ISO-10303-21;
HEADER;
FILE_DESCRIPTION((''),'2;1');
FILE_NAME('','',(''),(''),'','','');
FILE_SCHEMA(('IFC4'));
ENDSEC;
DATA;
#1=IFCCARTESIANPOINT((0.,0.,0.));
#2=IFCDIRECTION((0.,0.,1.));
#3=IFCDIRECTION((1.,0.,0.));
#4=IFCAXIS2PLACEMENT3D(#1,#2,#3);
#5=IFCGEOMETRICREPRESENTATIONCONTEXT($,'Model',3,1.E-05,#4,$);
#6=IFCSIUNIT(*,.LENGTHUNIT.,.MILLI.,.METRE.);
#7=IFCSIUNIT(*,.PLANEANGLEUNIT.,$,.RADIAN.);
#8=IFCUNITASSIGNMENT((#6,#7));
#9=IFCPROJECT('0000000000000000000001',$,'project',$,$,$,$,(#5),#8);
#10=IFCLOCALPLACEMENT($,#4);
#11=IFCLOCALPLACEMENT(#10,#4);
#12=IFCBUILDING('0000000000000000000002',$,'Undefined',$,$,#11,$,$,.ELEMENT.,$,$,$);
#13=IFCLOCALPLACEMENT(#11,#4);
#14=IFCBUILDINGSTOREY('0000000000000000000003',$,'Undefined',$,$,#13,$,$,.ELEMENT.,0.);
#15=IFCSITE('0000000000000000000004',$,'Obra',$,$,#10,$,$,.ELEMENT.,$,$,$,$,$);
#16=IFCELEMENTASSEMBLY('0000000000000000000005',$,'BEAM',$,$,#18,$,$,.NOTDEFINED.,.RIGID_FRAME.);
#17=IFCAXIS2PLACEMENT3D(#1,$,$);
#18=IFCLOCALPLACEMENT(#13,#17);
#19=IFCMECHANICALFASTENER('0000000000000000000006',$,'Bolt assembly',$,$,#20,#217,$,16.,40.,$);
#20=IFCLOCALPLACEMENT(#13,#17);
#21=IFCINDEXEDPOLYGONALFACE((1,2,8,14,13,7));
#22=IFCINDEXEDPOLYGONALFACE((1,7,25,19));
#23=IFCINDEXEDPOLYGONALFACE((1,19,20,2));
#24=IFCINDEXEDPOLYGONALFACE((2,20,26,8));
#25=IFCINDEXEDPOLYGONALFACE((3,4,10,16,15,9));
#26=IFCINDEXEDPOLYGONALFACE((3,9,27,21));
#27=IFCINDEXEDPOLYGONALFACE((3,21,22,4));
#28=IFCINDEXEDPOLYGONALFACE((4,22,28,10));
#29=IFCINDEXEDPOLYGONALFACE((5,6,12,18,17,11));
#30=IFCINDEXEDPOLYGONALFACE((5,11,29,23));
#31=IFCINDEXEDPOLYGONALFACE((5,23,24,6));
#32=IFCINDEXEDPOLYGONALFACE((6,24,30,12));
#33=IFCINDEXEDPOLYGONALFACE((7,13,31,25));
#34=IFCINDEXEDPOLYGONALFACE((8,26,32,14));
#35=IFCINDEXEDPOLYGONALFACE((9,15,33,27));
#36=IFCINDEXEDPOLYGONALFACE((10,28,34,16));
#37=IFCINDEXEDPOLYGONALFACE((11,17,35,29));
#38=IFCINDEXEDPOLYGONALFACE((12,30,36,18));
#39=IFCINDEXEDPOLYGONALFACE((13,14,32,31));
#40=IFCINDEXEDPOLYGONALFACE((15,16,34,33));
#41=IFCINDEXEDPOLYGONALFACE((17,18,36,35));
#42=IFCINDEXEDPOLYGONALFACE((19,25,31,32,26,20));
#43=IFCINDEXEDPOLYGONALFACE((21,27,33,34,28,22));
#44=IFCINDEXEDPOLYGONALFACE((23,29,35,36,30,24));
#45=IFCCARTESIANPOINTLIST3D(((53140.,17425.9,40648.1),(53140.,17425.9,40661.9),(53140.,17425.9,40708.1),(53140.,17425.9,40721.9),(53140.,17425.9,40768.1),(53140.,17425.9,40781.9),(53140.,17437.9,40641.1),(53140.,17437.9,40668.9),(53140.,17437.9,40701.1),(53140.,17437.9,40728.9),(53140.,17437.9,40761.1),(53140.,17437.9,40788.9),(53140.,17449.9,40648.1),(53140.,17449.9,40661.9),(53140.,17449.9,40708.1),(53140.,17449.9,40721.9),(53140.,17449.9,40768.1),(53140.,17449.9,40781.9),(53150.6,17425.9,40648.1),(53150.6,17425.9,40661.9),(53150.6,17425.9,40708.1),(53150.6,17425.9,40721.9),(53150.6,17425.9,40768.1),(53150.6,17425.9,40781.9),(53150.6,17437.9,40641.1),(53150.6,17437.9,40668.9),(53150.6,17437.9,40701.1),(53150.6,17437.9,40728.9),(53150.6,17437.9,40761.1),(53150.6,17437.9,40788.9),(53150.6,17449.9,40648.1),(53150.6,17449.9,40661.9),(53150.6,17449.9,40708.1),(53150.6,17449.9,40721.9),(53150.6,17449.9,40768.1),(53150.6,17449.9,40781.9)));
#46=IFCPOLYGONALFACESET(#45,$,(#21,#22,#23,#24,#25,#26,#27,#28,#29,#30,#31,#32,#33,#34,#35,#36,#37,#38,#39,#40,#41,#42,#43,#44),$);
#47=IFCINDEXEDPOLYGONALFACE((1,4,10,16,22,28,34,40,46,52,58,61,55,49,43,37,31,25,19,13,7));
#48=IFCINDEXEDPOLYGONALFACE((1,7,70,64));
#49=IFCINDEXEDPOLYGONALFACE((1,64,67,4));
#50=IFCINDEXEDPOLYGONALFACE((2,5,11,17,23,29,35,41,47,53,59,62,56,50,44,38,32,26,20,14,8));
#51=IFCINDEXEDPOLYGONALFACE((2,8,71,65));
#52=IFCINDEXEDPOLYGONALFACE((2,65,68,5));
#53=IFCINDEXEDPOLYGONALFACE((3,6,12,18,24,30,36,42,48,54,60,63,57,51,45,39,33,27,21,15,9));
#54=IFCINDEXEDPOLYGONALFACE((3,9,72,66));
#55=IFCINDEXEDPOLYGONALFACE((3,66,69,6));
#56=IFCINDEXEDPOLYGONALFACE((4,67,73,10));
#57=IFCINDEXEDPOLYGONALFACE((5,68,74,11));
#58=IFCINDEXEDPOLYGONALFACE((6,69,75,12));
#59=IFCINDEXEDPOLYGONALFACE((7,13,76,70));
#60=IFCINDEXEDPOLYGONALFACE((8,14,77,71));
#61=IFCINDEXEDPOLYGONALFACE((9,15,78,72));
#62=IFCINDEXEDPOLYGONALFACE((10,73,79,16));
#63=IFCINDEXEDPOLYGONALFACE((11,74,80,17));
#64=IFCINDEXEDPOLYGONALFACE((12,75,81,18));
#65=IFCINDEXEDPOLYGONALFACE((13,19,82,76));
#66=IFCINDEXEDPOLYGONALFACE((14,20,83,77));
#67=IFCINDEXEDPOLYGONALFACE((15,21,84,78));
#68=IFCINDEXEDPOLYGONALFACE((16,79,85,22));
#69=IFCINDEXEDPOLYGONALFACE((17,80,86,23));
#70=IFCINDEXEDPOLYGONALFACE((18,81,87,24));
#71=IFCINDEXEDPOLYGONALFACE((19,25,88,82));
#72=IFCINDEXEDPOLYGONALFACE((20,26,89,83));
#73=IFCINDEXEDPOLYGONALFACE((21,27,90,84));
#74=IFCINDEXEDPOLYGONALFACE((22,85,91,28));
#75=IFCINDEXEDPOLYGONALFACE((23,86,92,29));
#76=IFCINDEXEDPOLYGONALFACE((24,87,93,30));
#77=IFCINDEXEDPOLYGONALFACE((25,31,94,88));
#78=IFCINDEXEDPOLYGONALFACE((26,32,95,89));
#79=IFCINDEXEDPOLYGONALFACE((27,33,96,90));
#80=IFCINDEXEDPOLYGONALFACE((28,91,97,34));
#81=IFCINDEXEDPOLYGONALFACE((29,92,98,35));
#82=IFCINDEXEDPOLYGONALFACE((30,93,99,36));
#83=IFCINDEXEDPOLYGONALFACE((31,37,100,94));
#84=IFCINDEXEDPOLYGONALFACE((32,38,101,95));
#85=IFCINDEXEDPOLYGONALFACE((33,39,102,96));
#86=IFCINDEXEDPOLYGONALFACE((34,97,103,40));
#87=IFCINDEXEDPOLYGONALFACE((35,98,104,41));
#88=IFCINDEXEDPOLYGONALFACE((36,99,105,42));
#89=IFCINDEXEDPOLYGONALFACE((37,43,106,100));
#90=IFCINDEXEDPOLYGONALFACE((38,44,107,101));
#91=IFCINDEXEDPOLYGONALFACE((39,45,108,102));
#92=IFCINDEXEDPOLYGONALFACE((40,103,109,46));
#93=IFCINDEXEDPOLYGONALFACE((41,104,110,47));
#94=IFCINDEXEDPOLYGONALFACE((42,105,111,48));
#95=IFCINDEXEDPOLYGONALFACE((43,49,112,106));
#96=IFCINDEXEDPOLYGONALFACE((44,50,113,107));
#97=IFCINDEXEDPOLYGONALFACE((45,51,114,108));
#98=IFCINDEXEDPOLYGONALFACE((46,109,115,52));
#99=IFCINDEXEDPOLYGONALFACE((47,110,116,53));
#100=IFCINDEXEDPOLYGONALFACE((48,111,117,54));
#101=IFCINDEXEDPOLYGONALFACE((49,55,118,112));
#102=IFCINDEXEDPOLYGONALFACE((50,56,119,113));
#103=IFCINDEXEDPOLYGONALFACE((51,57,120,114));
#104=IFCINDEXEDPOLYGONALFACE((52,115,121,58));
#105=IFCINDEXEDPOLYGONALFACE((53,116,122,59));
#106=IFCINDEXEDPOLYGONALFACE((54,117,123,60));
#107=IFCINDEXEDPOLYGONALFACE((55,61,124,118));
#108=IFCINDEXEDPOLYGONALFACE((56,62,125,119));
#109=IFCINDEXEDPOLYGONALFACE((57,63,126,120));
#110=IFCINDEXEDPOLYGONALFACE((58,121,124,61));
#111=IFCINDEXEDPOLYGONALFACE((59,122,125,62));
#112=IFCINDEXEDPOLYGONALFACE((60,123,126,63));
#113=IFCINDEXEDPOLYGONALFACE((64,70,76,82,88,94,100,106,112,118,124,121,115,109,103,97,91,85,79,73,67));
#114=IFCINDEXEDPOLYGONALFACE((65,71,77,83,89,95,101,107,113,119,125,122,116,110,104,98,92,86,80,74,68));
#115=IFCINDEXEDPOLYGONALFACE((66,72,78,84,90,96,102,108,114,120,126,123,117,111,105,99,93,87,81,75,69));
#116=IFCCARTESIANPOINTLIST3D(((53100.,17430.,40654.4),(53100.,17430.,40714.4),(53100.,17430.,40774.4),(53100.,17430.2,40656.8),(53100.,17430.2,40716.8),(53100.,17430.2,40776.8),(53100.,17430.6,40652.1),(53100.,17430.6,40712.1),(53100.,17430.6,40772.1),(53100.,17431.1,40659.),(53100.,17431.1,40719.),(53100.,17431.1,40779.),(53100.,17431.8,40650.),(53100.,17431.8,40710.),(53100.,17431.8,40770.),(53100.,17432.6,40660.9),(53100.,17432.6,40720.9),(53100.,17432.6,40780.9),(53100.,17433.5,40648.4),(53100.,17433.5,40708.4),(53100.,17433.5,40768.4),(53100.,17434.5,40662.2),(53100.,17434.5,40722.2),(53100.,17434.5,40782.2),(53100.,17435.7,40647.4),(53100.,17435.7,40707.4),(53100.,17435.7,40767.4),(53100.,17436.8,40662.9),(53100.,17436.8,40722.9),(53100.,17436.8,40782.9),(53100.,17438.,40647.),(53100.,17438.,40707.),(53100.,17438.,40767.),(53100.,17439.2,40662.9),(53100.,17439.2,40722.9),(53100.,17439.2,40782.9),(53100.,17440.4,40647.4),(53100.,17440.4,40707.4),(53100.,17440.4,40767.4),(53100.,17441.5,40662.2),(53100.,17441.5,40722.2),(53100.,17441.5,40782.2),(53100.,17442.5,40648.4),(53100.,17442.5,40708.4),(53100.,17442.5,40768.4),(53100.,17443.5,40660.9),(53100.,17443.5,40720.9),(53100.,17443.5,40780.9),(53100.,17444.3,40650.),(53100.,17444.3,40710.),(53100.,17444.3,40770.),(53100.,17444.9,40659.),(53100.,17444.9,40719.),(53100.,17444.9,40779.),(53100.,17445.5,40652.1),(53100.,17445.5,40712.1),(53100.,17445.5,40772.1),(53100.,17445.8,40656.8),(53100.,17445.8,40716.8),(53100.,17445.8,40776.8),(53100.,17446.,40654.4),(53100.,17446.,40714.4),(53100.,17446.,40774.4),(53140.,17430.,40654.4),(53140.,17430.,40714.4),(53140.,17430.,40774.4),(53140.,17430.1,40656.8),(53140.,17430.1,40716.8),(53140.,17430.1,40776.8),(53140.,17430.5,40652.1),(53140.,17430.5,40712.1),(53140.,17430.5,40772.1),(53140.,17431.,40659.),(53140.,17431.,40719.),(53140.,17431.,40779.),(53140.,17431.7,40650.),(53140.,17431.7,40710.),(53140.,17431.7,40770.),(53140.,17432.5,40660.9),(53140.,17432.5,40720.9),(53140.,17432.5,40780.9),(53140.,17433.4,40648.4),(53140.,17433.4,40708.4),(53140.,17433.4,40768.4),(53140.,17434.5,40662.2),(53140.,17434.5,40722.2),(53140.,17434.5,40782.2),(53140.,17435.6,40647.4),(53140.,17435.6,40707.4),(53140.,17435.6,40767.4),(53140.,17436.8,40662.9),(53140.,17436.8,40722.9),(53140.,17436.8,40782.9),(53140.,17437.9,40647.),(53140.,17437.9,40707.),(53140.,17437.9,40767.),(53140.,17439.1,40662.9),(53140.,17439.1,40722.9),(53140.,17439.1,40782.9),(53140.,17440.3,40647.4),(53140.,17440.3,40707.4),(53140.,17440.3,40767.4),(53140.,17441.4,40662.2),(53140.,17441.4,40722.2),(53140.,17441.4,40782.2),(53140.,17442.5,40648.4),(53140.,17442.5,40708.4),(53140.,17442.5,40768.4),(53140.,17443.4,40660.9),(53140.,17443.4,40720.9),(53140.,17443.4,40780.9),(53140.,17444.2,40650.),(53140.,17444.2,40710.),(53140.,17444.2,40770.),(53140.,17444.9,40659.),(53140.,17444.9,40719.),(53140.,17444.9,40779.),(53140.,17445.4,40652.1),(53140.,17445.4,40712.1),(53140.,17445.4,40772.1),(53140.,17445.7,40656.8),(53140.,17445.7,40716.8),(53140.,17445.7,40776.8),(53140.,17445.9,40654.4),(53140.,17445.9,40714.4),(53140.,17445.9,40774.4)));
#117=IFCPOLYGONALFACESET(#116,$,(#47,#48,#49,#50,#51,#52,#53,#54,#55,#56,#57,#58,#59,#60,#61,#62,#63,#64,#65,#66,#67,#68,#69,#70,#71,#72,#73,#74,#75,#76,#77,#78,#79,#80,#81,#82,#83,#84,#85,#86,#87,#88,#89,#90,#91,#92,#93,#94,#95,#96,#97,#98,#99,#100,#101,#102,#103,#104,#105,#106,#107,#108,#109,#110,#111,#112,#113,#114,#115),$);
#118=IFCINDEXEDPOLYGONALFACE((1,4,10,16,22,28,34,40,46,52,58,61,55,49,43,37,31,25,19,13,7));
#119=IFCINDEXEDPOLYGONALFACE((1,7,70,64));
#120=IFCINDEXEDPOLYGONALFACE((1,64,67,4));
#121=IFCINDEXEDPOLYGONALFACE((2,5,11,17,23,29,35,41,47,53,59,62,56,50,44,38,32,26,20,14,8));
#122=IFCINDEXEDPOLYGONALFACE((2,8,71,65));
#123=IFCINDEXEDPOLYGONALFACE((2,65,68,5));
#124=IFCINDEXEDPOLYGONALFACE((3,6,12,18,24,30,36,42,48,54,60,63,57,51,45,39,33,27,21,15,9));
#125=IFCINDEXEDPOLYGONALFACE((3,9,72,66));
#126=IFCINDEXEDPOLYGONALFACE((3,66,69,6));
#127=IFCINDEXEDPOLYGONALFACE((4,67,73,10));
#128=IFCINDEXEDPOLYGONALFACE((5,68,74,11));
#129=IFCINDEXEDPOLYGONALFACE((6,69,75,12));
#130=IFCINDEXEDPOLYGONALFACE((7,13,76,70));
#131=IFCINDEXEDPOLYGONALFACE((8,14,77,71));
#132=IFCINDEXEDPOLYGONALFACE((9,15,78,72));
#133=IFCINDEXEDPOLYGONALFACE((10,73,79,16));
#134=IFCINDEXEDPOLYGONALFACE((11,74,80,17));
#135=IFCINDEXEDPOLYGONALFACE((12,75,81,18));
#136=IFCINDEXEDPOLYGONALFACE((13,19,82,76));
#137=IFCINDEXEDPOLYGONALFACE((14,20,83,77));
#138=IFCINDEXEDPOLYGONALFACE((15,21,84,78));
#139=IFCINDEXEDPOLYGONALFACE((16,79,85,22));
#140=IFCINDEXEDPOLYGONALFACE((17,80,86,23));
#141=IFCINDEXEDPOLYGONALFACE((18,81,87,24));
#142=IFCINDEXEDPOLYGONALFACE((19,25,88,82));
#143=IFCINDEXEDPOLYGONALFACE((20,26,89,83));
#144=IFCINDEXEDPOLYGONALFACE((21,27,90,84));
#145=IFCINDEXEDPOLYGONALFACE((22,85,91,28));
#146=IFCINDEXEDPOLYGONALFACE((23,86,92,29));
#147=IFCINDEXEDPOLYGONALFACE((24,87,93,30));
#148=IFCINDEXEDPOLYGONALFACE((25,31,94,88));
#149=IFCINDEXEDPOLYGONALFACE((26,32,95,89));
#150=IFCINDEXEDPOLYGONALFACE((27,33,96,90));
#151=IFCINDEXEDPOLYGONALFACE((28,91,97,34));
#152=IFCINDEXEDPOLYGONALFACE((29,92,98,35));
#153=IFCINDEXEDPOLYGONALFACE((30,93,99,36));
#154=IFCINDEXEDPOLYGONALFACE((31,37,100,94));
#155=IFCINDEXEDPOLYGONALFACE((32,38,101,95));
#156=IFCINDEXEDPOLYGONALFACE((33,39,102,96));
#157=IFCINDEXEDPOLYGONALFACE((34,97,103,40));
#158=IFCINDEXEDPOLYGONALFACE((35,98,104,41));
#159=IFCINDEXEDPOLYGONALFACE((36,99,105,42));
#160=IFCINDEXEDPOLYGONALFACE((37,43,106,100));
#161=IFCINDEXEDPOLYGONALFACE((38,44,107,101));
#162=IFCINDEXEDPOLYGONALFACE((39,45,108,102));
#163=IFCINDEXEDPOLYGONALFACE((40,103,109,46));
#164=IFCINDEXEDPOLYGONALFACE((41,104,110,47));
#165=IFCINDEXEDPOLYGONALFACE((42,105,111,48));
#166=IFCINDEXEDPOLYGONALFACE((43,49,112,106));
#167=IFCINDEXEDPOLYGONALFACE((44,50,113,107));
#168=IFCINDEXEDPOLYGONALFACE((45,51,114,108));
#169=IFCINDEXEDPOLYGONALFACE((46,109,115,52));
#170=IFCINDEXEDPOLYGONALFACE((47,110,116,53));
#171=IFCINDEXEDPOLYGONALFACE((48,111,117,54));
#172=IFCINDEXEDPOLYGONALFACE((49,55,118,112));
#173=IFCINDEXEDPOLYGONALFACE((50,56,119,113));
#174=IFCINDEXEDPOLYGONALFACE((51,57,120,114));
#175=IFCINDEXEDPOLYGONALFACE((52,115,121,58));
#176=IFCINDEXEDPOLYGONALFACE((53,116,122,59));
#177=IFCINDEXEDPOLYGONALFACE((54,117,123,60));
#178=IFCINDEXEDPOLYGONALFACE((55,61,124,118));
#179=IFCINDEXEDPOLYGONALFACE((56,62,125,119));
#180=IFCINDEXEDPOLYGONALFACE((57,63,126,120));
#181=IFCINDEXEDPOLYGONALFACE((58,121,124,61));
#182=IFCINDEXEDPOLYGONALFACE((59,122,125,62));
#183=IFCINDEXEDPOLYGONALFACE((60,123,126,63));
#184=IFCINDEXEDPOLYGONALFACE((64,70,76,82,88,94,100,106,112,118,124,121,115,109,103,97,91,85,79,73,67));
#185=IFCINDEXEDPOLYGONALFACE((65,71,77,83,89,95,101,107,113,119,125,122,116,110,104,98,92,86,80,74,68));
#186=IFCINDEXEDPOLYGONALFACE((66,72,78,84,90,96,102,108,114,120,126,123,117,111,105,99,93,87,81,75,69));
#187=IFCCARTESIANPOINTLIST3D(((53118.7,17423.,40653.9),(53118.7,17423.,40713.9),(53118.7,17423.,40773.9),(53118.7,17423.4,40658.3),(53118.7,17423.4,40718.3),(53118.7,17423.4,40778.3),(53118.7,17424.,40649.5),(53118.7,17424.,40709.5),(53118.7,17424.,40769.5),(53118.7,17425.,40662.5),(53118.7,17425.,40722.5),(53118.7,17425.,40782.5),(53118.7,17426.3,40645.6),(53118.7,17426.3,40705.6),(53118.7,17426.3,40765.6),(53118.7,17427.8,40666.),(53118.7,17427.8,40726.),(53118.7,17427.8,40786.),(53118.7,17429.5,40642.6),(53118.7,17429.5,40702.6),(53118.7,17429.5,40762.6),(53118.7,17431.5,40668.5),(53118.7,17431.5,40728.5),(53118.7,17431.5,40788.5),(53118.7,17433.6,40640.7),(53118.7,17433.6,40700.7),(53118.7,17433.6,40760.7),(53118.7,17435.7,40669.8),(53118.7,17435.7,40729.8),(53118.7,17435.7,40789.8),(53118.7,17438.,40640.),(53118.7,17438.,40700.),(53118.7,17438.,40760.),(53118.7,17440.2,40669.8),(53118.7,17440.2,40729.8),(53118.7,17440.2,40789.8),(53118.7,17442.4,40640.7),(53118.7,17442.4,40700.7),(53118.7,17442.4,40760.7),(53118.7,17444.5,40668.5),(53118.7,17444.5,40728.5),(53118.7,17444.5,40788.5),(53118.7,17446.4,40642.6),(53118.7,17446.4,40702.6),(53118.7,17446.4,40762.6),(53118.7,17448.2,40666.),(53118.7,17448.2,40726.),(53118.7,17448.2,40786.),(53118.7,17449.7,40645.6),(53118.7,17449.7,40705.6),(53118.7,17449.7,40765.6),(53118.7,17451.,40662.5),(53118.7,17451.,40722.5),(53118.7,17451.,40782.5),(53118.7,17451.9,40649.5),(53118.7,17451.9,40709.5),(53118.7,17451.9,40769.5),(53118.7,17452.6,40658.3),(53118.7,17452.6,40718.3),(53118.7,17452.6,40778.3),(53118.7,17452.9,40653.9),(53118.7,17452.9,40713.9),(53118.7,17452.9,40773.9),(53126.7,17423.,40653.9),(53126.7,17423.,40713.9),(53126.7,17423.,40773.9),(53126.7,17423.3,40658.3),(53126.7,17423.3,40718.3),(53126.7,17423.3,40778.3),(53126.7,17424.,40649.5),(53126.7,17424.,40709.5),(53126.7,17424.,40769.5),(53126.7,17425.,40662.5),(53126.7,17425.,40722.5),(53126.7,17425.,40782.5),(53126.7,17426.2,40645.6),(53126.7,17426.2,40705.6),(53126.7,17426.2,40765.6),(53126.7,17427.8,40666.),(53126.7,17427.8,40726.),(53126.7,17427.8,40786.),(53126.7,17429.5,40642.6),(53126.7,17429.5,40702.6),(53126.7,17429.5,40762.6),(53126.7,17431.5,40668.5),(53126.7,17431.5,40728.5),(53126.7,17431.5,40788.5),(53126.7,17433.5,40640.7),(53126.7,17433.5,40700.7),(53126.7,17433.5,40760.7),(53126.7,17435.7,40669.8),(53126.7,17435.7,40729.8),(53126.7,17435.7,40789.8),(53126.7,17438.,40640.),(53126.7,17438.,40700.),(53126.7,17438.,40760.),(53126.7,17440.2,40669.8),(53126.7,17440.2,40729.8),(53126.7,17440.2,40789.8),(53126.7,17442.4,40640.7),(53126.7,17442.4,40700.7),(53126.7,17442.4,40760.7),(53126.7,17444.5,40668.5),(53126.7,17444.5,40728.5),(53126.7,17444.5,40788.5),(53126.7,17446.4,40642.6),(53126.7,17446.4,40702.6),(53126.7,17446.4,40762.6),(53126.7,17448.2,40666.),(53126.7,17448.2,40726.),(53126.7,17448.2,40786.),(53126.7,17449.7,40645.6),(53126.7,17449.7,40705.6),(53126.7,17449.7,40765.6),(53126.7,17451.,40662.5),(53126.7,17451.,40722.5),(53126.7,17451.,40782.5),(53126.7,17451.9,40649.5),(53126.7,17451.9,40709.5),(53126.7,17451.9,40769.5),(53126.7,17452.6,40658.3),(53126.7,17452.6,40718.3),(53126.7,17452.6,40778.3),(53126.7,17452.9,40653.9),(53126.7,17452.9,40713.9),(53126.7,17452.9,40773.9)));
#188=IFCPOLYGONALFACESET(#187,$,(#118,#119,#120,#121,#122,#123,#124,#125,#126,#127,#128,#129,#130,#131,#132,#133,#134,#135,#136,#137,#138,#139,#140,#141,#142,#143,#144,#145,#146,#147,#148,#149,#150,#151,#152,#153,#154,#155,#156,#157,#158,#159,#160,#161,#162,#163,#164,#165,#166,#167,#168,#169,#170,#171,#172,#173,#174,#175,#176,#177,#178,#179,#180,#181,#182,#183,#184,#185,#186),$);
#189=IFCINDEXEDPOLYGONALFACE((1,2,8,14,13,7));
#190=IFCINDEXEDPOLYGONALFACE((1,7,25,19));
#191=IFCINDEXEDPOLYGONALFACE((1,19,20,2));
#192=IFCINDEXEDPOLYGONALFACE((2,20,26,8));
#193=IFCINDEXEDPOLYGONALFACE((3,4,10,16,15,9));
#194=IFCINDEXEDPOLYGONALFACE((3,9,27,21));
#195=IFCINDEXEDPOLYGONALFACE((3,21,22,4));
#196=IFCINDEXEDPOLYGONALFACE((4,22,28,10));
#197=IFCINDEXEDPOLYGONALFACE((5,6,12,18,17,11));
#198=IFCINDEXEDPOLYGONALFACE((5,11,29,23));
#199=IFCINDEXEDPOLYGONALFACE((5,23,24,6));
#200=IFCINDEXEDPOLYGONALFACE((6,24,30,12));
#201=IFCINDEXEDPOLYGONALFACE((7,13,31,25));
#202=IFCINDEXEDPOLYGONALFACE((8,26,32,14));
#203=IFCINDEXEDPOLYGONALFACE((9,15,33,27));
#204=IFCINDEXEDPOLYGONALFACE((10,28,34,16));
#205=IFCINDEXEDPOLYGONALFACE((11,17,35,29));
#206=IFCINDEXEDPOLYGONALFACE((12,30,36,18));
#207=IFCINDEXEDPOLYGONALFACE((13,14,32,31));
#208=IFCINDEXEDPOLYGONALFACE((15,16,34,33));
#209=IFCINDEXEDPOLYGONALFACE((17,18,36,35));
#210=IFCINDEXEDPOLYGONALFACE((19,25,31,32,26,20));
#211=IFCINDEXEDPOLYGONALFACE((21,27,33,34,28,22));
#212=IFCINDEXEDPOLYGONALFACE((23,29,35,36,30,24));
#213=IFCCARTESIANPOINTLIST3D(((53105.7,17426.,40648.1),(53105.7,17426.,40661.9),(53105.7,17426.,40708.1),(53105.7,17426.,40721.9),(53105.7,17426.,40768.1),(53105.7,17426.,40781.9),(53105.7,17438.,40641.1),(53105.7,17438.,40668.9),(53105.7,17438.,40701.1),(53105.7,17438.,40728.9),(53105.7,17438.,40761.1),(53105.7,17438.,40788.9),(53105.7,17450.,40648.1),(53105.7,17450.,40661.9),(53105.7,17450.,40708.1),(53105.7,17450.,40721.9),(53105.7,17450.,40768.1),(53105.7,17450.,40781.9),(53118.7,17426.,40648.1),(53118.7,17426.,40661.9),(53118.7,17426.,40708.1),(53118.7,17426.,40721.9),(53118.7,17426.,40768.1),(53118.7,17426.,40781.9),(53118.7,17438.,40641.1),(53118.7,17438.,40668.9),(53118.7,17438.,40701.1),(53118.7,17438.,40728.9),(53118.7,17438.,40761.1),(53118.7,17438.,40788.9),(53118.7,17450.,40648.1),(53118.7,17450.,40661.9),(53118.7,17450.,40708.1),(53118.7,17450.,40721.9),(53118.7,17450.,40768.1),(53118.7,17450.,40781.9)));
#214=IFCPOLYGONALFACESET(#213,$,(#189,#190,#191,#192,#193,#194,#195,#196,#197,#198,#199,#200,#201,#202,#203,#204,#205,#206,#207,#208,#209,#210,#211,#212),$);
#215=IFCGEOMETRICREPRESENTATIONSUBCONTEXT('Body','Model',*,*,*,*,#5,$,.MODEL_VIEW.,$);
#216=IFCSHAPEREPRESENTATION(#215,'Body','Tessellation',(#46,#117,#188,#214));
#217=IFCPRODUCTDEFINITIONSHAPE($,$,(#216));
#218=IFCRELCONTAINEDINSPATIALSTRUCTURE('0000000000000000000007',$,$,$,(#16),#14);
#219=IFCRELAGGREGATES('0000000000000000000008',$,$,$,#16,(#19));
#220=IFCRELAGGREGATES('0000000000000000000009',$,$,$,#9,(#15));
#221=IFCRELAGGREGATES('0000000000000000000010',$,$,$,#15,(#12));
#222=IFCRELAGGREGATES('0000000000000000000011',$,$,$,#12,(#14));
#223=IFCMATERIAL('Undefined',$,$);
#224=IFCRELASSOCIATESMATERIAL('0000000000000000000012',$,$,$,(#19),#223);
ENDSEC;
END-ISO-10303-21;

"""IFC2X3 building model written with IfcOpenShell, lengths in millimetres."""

from ifc_helpers import new_model, si_unit, frame, origin_with_axes, origin_2d_with_axis, place, context, subcontext, project, spatial, polyline, circle, outline, extrude, source, transform, mapped, material, element, aggregate, save


model = new_model("IFC2X3")

# Units and contexts
model_context = context("Model", 3, precision=1e-05, world=origin_with_axes())
body_context = subcontext(model_context, "Body", "Model", "MODEL_VIEW")
ifc_project = project(units=[si_unit("LENGTHUNIT", "METRE", prefix="MILLI"), si_unit("PLANEANGLEUNIT", "RADIAN")], contexts=[model_context])

# Site, building, storey
site_placement = place(None, origin_with_axes())
site = spatial("IfcSite", under=ifc_project, at=site_placement, Name="Obra", CompositionType="ELEMENT")
building_placement = place(site_placement, origin_with_axes())
building = spatial("IfcBuilding", under=site, at=building_placement, Name="Undefined", CompositionType="ELEMENT")
storey_placement = place(building_placement, origin_with_axes())
storey = spatial("IfcBuildingStorey", under=building, at=storey_placement, Name="Undefined", CompositionType="ELEMENT", Elevation=0.0)

# Element assembly
assembly_1_placement = place(storey_placement, origin_with_axes())
assembly_1 = element("IfcElementAssembly", 1, at=assembly_1_placement, inside=storey, Name="BEAM", AssemblyPlace="NOTDEFINED", PredefinedType="RIGID_FRAME")

# Mechanical fastener
ifc_material_1 = material(Name="Undefined")
shared_shape_1 = source(origin_with_axes(), body_context, "Body", "SweptSolid", [
    extrude(outline(polyline([(13.9, 0.0), (6.9, 12.0), (-6.9, 12.0), (-13.9, 0.0), (-6.9, -12.0), (6.9, -12.0), (13.9, 0.0)])), frame((0.0, -19.7, 0.0), z_axis=(0.0, 1.0, 0.0), x_axis=(1.0, 0.0, 0.0)), (0.0, 0.0, 1.0), 10.6),
    extrude(circle(Radius=8.0, at=origin_2d_with_axis()), frame((0.0, -9.1, 0.0), z_axis=(0.0, 1.0, 0.0), x_axis=(1.0, 0.0, 0.0)), (0.0, 0.0, 1.0), 40.0),
    extrude(circle(Radius=15.0, at=origin_2d_with_axis()), frame((0.0, 4.2, 0.0), z_axis=(0.0, 1.0, 0.0), x_axis=(1.0, 0.0, 0.0)), (0.0, 0.0, 1.0), 8.0),
    extrude(outline(polyline([(13.9, 0.0), (6.9, 12.0), (-6.9, 12.0), (-13.9, 0.0), (-6.9, -12.0), (6.9, -12.0), (13.9, 0.0)])), frame((0.0, 12.2, 0.0), z_axis=(0.0, 1.0, 0.0), x_axis=(1.0, 0.0, 0.0)), (0.0, 0.0, 1.0), 13.0),
])
mechanical_fastener_1_placement = place(assembly_1_placement, frame((53130.8, 17388.0, 40835.0), z_axis=(0.001649, 0.999999, 0.0), x_axis=(0.0, 0.0, -1.0)))
mechanical_fastener_1 = element("IfcMechanicalFastener", 2, at=mechanical_fastener_1_placement, material=ifc_material_1, Name="Bolt assembly", NominalDiameter=16.0, NominalLength=40.0, context=body_context, shape_type="MappedRepresentation", body=[
    mapped(shared_shape_1, transform((60.0, 0.0, 50.0))),
    mapped(shared_shape_1, transform((120.0, 0.0, 50.0))),
    mapped(shared_shape_1, transform((180.0, 0.0, 50.0))),
])
aggregate(assembly_1, [mechanical_fastener_1])

save(model, "model.ifc")
